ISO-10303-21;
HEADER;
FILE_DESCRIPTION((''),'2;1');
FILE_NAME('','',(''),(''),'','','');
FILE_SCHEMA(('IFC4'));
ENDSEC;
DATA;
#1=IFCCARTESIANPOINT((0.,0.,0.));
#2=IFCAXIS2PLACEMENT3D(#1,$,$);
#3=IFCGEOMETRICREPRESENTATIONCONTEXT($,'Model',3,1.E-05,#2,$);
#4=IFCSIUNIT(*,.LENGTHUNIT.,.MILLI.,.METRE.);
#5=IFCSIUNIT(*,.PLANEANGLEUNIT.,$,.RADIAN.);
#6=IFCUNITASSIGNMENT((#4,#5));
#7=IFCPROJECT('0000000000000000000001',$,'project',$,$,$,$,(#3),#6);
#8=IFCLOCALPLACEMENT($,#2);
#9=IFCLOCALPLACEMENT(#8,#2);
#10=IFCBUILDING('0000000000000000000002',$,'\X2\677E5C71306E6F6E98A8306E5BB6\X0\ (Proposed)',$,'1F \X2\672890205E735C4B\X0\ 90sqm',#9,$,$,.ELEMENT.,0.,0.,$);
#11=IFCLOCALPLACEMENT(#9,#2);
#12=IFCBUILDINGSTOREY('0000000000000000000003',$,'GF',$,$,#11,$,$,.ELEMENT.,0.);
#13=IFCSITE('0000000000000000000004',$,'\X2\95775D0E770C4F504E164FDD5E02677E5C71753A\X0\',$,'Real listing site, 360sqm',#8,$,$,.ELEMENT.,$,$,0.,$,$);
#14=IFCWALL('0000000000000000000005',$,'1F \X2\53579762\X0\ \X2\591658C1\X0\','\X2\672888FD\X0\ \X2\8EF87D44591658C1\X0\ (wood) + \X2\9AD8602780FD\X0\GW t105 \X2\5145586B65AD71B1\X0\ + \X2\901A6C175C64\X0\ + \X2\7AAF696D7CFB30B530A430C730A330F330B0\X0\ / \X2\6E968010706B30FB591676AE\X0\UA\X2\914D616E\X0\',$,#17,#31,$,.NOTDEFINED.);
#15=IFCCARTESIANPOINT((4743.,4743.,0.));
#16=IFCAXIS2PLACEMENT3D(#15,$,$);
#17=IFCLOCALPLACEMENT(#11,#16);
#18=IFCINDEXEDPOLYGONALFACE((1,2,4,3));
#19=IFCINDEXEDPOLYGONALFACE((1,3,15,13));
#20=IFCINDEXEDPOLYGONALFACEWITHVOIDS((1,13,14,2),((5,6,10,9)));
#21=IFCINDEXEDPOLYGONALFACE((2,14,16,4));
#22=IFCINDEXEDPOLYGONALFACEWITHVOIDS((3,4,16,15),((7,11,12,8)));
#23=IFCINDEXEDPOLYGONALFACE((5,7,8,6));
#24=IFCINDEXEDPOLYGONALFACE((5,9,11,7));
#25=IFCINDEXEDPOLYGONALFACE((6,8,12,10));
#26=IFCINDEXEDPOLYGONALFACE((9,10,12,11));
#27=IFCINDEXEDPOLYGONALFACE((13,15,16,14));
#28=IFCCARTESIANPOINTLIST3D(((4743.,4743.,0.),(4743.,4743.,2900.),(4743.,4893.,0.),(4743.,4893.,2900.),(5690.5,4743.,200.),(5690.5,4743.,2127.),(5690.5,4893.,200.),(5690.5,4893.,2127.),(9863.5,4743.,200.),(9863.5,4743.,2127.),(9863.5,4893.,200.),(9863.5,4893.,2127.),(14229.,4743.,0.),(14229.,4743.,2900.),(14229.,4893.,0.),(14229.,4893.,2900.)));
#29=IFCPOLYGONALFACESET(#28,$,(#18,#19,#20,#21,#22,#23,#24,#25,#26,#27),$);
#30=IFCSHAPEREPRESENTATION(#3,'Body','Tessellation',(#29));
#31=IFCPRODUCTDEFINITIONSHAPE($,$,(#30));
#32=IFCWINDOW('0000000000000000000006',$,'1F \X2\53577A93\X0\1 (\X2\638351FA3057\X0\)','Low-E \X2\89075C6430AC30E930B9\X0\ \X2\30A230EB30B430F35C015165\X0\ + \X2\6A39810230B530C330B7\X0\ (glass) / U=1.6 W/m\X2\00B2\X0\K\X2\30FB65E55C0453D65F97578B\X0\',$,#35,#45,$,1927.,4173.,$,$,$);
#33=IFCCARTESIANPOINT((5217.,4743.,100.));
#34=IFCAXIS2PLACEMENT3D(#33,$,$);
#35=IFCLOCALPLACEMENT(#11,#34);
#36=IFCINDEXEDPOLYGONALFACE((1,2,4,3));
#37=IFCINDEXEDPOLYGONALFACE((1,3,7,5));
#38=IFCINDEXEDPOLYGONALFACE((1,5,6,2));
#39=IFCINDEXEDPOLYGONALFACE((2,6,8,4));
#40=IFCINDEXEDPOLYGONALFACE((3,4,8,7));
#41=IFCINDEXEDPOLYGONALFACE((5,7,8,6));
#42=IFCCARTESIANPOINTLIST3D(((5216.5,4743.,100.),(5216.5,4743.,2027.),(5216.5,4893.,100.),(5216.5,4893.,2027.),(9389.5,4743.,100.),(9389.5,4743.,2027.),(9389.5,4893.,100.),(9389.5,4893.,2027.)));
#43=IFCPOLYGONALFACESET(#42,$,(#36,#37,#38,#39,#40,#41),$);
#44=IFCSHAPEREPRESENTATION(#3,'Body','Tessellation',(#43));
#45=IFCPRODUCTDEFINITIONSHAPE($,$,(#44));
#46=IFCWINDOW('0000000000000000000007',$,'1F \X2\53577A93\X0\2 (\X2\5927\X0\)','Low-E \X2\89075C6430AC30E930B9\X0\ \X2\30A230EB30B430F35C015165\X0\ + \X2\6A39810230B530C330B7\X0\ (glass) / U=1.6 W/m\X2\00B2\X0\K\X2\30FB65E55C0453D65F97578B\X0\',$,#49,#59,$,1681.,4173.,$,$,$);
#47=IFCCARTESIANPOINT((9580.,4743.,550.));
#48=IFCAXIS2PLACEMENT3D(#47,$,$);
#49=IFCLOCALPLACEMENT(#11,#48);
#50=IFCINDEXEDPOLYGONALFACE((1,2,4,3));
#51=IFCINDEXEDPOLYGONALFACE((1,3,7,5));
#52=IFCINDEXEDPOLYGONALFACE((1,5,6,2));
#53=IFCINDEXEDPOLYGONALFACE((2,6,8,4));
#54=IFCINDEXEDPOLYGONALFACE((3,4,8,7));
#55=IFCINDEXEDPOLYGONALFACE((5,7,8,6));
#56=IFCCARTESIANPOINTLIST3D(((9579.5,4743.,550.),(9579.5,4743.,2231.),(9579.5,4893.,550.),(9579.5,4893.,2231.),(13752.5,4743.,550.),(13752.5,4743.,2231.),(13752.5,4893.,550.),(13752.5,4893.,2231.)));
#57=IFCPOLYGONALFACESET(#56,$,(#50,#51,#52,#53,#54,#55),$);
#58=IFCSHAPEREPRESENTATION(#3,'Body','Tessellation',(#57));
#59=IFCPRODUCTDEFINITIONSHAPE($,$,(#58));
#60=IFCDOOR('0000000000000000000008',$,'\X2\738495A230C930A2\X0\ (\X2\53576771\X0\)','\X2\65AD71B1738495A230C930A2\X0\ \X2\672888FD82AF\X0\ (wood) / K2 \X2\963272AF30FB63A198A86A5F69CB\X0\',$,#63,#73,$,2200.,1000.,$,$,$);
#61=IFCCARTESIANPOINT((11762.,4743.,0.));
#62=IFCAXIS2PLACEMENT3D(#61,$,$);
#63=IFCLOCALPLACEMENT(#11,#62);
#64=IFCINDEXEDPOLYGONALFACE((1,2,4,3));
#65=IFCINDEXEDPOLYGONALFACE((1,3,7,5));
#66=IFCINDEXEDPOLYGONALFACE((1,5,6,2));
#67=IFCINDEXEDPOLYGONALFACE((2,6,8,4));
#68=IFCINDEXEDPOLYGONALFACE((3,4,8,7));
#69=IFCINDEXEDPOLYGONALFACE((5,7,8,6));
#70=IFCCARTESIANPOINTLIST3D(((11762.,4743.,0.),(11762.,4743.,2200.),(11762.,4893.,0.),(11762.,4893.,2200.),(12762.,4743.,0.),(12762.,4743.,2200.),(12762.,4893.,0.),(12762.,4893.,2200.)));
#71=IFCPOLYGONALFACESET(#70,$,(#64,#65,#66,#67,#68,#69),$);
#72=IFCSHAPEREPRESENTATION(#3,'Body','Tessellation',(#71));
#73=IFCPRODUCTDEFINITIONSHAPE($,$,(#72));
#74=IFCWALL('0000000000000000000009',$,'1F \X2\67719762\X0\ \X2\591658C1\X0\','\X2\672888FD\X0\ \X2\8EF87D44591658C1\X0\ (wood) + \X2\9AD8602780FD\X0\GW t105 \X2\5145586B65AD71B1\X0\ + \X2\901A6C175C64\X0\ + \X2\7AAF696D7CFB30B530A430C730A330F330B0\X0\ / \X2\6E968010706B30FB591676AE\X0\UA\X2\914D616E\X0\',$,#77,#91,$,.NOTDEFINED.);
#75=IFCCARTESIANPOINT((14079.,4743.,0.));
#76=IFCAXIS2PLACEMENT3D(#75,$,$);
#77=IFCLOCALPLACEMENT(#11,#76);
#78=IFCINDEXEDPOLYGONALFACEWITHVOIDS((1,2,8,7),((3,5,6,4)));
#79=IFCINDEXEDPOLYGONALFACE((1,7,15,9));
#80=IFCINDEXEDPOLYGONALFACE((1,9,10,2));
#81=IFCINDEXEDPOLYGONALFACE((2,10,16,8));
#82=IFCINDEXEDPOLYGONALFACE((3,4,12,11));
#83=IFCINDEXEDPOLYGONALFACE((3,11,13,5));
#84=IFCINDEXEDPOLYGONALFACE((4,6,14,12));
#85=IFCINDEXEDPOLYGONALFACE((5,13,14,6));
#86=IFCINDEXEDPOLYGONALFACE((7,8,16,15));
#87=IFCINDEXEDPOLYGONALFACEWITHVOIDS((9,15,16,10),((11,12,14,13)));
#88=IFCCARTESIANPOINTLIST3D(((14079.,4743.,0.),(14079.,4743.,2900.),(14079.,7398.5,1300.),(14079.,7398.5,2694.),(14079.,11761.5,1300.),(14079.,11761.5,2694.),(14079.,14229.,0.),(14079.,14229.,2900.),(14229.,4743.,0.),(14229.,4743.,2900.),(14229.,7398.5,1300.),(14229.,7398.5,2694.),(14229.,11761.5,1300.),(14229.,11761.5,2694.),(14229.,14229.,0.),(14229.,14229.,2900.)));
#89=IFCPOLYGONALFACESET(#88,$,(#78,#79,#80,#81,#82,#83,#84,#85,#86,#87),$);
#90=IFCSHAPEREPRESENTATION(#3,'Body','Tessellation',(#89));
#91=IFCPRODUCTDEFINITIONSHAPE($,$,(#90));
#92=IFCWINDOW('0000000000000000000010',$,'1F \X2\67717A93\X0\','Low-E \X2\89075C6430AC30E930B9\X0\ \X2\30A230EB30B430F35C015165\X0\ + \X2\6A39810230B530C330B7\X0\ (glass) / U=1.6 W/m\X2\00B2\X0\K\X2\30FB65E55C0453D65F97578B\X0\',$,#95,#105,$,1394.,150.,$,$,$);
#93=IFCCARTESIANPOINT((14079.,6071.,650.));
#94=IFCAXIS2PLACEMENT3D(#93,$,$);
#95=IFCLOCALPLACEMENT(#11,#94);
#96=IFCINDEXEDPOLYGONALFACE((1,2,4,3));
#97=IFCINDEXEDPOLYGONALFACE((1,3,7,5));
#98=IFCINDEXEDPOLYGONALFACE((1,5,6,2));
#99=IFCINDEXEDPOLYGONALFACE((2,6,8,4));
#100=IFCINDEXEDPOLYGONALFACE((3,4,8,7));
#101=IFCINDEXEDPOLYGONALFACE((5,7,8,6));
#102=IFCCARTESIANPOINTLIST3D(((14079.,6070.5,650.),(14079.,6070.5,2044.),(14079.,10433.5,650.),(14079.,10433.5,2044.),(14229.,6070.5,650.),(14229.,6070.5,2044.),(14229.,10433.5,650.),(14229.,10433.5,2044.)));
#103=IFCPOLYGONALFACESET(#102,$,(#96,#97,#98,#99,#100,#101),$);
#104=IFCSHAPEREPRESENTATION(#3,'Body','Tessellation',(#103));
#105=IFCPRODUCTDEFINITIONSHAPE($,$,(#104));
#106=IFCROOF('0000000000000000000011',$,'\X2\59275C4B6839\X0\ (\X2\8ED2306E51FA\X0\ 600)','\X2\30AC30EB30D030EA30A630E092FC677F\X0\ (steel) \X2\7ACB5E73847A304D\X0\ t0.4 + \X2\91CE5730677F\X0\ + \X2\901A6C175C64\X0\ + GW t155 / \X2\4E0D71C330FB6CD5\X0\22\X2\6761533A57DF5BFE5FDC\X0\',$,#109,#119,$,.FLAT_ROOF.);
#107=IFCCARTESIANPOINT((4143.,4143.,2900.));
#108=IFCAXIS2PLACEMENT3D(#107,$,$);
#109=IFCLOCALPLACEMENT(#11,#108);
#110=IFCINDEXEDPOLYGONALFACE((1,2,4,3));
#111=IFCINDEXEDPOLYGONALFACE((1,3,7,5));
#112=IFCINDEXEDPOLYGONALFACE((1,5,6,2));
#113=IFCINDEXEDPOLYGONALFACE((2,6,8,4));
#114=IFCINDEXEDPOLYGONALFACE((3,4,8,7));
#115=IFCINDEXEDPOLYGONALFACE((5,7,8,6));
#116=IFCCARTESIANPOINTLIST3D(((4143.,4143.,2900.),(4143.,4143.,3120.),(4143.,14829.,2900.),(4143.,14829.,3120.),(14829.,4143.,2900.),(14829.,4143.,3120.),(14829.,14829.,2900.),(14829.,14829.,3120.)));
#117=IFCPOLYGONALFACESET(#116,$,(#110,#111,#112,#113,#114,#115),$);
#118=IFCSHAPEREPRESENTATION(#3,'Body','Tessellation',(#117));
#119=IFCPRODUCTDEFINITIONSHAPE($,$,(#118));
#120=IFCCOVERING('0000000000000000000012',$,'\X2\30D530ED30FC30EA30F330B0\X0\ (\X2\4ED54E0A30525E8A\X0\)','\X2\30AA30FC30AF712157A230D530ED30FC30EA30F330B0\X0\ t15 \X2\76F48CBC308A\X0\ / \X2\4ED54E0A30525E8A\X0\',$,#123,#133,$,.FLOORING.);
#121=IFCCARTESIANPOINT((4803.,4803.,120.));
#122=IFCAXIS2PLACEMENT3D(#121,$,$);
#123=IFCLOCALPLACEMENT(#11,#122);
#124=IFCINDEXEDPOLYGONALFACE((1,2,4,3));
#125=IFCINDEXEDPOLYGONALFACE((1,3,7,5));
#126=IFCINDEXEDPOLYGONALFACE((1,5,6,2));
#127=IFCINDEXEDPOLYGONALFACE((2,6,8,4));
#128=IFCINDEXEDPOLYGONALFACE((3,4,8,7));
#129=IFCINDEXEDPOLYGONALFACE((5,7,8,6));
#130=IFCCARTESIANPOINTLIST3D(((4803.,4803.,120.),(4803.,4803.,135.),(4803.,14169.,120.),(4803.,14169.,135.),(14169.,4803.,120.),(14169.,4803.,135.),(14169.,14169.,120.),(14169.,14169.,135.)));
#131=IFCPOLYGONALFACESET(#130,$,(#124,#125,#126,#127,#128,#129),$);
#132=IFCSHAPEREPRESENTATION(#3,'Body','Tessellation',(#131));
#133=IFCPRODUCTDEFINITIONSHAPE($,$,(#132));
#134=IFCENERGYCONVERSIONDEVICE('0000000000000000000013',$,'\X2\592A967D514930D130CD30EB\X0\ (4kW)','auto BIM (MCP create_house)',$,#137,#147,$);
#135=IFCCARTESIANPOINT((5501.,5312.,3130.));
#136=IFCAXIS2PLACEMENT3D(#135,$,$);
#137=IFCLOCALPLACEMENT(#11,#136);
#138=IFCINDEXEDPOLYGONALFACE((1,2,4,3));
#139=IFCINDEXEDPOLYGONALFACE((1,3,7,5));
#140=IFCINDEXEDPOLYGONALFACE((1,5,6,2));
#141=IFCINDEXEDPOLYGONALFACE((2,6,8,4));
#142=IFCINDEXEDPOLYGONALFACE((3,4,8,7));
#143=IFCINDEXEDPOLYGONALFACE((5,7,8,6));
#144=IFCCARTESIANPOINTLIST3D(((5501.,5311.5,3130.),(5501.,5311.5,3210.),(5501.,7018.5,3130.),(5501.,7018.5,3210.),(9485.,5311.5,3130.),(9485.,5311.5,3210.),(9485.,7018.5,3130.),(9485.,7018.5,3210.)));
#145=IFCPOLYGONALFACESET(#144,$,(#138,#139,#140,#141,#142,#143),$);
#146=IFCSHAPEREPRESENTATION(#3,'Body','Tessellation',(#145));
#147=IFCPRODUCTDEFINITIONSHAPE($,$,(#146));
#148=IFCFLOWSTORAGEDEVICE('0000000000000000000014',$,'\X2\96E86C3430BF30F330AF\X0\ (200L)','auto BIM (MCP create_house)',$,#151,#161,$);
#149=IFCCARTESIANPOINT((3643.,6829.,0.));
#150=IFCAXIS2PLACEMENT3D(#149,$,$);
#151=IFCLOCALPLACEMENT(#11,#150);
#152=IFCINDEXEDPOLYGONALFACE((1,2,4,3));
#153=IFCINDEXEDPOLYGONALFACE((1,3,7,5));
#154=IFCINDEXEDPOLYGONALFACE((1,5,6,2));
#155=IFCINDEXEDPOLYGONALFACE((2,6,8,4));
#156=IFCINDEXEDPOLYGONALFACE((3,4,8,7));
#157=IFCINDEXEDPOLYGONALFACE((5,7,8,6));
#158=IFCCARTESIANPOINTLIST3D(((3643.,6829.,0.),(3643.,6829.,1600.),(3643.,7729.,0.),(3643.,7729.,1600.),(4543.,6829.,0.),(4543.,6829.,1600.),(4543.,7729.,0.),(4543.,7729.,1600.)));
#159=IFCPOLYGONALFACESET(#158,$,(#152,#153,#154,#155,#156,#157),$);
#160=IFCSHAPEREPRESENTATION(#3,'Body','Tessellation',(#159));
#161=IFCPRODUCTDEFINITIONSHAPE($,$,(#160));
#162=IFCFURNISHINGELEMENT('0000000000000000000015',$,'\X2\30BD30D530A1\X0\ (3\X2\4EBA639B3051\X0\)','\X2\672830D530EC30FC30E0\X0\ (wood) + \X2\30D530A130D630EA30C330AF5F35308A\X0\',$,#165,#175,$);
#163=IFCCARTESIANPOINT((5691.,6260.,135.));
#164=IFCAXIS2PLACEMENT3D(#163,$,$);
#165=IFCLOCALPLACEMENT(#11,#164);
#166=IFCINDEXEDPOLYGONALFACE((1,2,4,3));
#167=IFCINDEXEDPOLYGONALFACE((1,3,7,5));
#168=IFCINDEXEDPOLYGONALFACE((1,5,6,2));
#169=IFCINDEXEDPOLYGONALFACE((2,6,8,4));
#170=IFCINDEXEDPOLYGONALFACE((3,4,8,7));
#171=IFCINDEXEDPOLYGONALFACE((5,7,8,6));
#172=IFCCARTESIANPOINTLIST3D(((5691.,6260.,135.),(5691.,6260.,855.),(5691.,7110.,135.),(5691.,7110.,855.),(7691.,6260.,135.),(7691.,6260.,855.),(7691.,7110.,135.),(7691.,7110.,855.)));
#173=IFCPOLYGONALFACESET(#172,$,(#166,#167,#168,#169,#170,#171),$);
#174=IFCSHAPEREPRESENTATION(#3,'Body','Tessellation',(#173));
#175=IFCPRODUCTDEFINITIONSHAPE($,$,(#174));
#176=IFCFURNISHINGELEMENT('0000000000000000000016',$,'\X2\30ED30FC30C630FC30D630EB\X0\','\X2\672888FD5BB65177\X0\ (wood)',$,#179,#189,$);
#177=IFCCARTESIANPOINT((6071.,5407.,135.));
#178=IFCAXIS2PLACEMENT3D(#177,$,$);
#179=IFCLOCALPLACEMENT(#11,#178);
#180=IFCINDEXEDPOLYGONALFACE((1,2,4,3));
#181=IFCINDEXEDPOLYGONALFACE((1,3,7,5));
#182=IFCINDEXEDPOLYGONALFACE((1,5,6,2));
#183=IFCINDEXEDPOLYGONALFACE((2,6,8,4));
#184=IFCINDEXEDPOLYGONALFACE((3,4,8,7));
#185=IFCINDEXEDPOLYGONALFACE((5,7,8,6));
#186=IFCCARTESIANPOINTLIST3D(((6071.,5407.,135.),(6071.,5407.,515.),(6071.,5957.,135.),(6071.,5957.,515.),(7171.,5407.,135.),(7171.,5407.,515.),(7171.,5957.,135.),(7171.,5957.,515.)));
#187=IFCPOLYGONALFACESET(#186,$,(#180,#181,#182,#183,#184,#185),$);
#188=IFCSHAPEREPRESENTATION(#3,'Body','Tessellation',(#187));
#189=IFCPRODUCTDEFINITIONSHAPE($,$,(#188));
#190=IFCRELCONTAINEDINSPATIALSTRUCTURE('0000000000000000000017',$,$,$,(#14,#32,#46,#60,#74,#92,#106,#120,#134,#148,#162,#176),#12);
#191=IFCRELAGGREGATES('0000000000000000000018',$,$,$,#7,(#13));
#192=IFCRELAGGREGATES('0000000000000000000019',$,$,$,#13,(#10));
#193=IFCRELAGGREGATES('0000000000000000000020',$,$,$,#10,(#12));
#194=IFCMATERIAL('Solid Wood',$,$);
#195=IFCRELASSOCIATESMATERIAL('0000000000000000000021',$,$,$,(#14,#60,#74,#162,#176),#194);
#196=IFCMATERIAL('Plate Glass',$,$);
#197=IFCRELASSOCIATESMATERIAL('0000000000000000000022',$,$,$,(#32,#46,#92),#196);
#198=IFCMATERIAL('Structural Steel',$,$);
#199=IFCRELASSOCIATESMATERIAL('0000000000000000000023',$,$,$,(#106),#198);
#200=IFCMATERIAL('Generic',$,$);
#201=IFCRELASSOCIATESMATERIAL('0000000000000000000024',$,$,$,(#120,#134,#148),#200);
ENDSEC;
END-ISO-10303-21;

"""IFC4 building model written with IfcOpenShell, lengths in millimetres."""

from ifc_helpers import new_model, si_unit, frame, frame_2d, origin, place, context, project, spatial, rectangle, extrude, material, element, fill, save


model = new_model("IFC4")

# Units and contexts
model_context = context("Model", 3, precision=1e-05, world=origin())
ifc_project = project(units=[si_unit("LENGTHUNIT", "METRE", prefix="MILLI"), si_unit("PLANEANGLEUNIT", "RADIAN")], contexts=[model_context])

# Site, building, storey
site_placement = place(None, origin())
site = spatial("IfcSite", under=ifc_project, at=site_placement, Name="長崎県佐世保市松山町", ObjectType="Real listing site, 360sqm", CompositionType="ELEMENT", RefElevation=0.0)
building_placement = place(site_placement, origin())
building = spatial("IfcBuilding", under=site, at=building_placement, Name="松山の潮風の家 (Proposed)", ObjectType="1F 木造平屋 90sqm", CompositionType="ELEMENT", ElevationOfRefHeight=0.0, ElevationOfTerrain=0.0)
storey_placement = place(building_placement, origin())
storey = spatial("IfcBuildingStorey", under=building, at=storey_placement, Name="GF", CompositionType="ELEMENT", Elevation=0.0)

# Shared definitions
ifc_material_1 = material(Name="Solid Wood")

# Wall, openings, windows, door
wall_1_placement = place(storey_placement, frame((4743.0, 4743.0, 0.0)))
wall_1 = element("IfcWall", 1, at=wall_1_placement, inside=storey, material=ifc_material_1, Name="1F 南面 外壁", Description="木製 軸組外壁 (wood) + 高性能GW t105 充填断熱 + 通気層 + 窯業系サイディング / 準耐火・外皮UA配慮", PredefinedType="NOTDEFINED", context=model_context, shape_type="SweptSolid", body=[
    extrude(rectangle(XDim=9486.0, YDim=150.0, at=frame_2d((4743.0, 75.0))), frame((4743.0, 4743.0, 0.0)), (0.0, 0.0, 1.0), 2900.0),
])
opening_1_placement = place(storey_placement, frame((5217.0, 4743.0, 100.0)))
opening_1 = element("IfcOpeningElement", 2, at=opening_1_placement, cuts=wall_1, PredefinedType="NOTDEFINED", context=model_context, shape_type="SweptSolid", body=[
    extrude(rectangle(XDim=4173.0, YDim=150.0, at=frame_2d((2086.0, 75.0))), frame((5217.0, 4743.0, 100.0)), (0.0, 0.0, 1.0), 1927.0),
])
opening_2_placement = place(storey_placement, frame((9580.0, 4743.0, 550.0)))
opening_2 = element("IfcOpeningElement", 3, at=opening_2_placement, cuts=wall_1, PredefinedType="NOTDEFINED", context=model_context, shape_type="SweptSolid", body=[
    extrude(rectangle(XDim=4173.0, YDim=150.0, at=frame_2d((2086.0, 75.0))), frame((9580.0, 4743.0, 550.0)), (0.0, 0.0, 1.0), 1681.0),
])
opening_3_placement = place(storey_placement, frame((11762.0, 4743.0, 0.0)))
opening_3 = element("IfcOpeningElement", 4, at=opening_3_placement, cuts=wall_1, PredefinedType="NOTDEFINED", context=model_context, shape_type="SweptSolid", body=[
    extrude(rectangle(XDim=1000.0, YDim=150.0, at=frame_2d((500.0, 75.0))), frame((11762.0, 4743.0, 0.0)), (0.0, 0.0, 1.0), 2200.0),
])
ifc_material_2 = material(Name="Plate Glass")
window_1_placement = place(storey_placement, frame((5217.0, 4743.0, 100.0)))
window_1 = element("IfcWindow", 5, at=window_1_placement, inside=storey, material=ifc_material_2, Name="1F 南窓1 (掃出し)", Description="Low-E 複層ガラス アルゴン封入 + 樹脂サッシ (glass) / U=1.6 W/m²K・日射取得型", OverallHeight=1927.0, OverallWidth=4173.0, context=model_context, shape_type="SweptSolid", body=[
    extrude(rectangle(XDim=4173.0, YDim=150.0, at=frame_2d((2086.0, 75.0))), frame((5217.0, 4743.0, 100.0)), (0.0, 0.0, 1.0), 1927.0),
])
fill(opening_1, window_1)
window_2_placement = place(storey_placement, frame((9580.0, 4743.0, 550.0)))
window_2 = element("IfcWindow", 6, at=window_2_placement, inside=storey, material=ifc_material_2, Name="1F 南窓2 (大)", Description="Low-E 複層ガラス アルゴン封入 + 樹脂サッシ (glass) / U=1.6 W/m²K・日射取得型", OverallHeight=1681.0, OverallWidth=4173.0, context=model_context, shape_type="SweptSolid", body=[
    extrude(rectangle(XDim=4173.0, YDim=150.0, at=frame_2d((2086.0, 75.0))), frame((9580.0, 4743.0, 550.0)), (0.0, 0.0, 1.0), 1681.0),
])
fill(opening_2, window_2)
door_placement = place(storey_placement, frame((11762.0, 4743.0, 0.0)))
door = element("IfcDoor", 7, at=door_placement, inside=storey, material=ifc_material_1, Name="玄関ドア (南東)", Description="断熱玄関ドア 木製芯 (wood) / K2 防犯・採風機構", OverallHeight=2200.0, OverallWidth=1000.0, context=model_context, shape_type="SweptSolid", body=[
    extrude(rectangle(XDim=1000.0, YDim=150.0, at=frame_2d((500.0, 75.0))), frame((11762.0, 4743.0, 0.0)), (0.0, 0.0, 1.0), 2200.0),
])
fill(opening_3, door)

# Wall, opening, window
wall_2_placement = place(storey_placement, frame((14079.0, 4743.0, 0.0)))
wall_2 = element("IfcWall", 8, at=wall_2_placement, inside=storey, material=ifc_material_1, Name="1F 東面 外壁", Description="木製 軸組外壁 (wood) + 高性能GW t105 充填断熱 + 通気層 + 窯業系サイディング / 準耐火・外皮UA配慮", PredefinedType="NOTDEFINED", context=model_context, shape_type="SweptSolid", body=[
    extrude(rectangle(XDim=150.0, YDim=9486.0, at=frame_2d((75.0, 4743.0))), frame((14079.0, 4743.0, 0.0)), (0.0, 0.0, 1.0), 2900.0),
])
opening_4_placement = place(storey_placement, frame((14079.0, 6071.0, 650.0)))
opening_4 = element("IfcOpeningElement", 9, at=opening_4_placement, cuts=wall_2, PredefinedType="NOTDEFINED", context=model_context, shape_type="SweptSolid", body=[
    extrude(rectangle(XDim=150.0, YDim=4363.0, at=frame_2d((75.0, 2181.0))), frame((14079.0, 6071.0, 650.0)), (0.0, 0.0, 1.0), 1394.0),
])
window_3_placement = place(storey_placement, frame((14079.0, 6071.0, 650.0)))
window_3 = element("IfcWindow", 10, at=window_3_placement, inside=storey, material=ifc_material_2, Name="1F 東窓", Description="Low-E 複層ガラス アルゴン封入 + 樹脂サッシ (glass) / U=1.6 W/m²K・日射取得型", OverallHeight=1394.0, OverallWidth=150.0, context=model_context, shape_type="SweptSolid", body=[
    extrude(rectangle(XDim=150.0, YDim=4363.0, at=frame_2d((75.0, 2181.0))), frame((14079.0, 6071.0, 650.0)), (0.0, 0.0, 1.0), 1394.0),
])
fill(opening_4, window_3)

# Roof
ifc_material_3 = material(Name="Structural Steel")
roof_placement = place(storey_placement, frame((4143.0, 4143.0, 2900.0)))
element("IfcRoof", 11, at=roof_placement, inside=storey, material=ifc_material_3, Name="大屋根 (軒の出 600)", Description="ガルバリウム鋼板 (steel) 立平葺き t0.4 + 野地板 + 通気層 + GW t155 / 不燃・法22条区域対応", PredefinedType="FLAT_ROOF", context=model_context, shape_type="SweptSolid", body=[
    extrude(rectangle(XDim=10686.0, YDim=10686.0, at=frame_2d((5343.0, 5343.0))), frame((4143.0, 4143.0, 2900.0)), (0.0, 0.0, 1.0), 220.0),
])

# Covering
ifc_material_4 = material(Name="Generic")
covering_placement = place(storey_placement, frame((4803.0, 4803.0, 120.0)))
element("IfcCovering", 12, at=covering_placement, inside=storey, material=ifc_material_4, Name="フローリング (仕上げ床)", Description="オーク無垢フローリング t15 直貼り / 仕上げ床", PredefinedType="FLOORING", context=model_context, shape_type="SweptSolid", body=[
    extrude(rectangle(XDim=9366.0, YDim=9366.0, at=frame_2d((4683.0, 4683.0))), frame((4803.0, 4803.0, 120.0)), (0.0, 0.0, 1.0), 15.0),
])

# Energy conversion device
energy_conversion_device_placement = place(storey_placement, frame((5501.0, 5312.0, 3130.0)))
element("IfcEnergyConversionDevice", 13, at=energy_conversion_device_placement, inside=storey, material=ifc_material_4, Name="太陽光パネル (4kW)", Description="auto BIM (MCP create_house)", context=model_context, shape_type="SweptSolid", body=[
    extrude(rectangle(XDim=3984.0, YDim=1707.0, at=frame_2d((1992.0, 853.0))), frame((5501.0, 5312.0, 3130.0)), (0.0, 0.0, 1.0), 80.0),
])

# Flow storage device
flow_storage_device_placement = place(storey_placement, frame((3643.0, 6829.0, 0.0)))
element("IfcFlowStorageDevice", 14, at=flow_storage_device_placement, inside=storey, material=ifc_material_4, Name="雨水タンク (200L)", Description="auto BIM (MCP create_house)", context=model_context, shape_type="SweptSolid", body=[
    extrude(rectangle(XDim=900.0, YDim=900.0, at=frame_2d((450.0, 450.0))), frame((3643.0, 6829.0, 0.0)), (0.0, 0.0, 1.0), 1600.0),
])

# Furnishing elements
furnishing_1_placement = place(storey_placement, frame((5691.0, 6260.0, 135.0)))
element("IfcFurnishingElement", 15, at=furnishing_1_placement, inside=storey, material=ifc_material_1, Name="ソファ (3人掛け)", Description="木フレーム (wood) + ファブリック張り", context=model_context, shape_type="SweptSolid", body=[
    extrude(rectangle(XDim=2000.0, YDim=850.0, at=frame_2d((1000.0, 425.0))), frame((5691.0, 6260.0, 135.0)), (0.0, 0.0, 1.0), 720.0),
])
furnishing_2_placement = place(storey_placement, frame((6071.0, 5407.0, 135.0)))
element("IfcFurnishingElement", 16, at=furnishing_2_placement, inside=storey, material=ifc_material_1, Name="ローテーブル", Description="木製家具 (wood)", context=model_context, shape_type="SweptSolid", body=[
    extrude(rectangle(XDim=1100.0, YDim=550.0, at=frame_2d((550.0, 275.0))), frame((6071.0, 5407.0, 135.0)), (0.0, 0.0, 1.0), 380.0),
])

save(model, "model.ifc")
